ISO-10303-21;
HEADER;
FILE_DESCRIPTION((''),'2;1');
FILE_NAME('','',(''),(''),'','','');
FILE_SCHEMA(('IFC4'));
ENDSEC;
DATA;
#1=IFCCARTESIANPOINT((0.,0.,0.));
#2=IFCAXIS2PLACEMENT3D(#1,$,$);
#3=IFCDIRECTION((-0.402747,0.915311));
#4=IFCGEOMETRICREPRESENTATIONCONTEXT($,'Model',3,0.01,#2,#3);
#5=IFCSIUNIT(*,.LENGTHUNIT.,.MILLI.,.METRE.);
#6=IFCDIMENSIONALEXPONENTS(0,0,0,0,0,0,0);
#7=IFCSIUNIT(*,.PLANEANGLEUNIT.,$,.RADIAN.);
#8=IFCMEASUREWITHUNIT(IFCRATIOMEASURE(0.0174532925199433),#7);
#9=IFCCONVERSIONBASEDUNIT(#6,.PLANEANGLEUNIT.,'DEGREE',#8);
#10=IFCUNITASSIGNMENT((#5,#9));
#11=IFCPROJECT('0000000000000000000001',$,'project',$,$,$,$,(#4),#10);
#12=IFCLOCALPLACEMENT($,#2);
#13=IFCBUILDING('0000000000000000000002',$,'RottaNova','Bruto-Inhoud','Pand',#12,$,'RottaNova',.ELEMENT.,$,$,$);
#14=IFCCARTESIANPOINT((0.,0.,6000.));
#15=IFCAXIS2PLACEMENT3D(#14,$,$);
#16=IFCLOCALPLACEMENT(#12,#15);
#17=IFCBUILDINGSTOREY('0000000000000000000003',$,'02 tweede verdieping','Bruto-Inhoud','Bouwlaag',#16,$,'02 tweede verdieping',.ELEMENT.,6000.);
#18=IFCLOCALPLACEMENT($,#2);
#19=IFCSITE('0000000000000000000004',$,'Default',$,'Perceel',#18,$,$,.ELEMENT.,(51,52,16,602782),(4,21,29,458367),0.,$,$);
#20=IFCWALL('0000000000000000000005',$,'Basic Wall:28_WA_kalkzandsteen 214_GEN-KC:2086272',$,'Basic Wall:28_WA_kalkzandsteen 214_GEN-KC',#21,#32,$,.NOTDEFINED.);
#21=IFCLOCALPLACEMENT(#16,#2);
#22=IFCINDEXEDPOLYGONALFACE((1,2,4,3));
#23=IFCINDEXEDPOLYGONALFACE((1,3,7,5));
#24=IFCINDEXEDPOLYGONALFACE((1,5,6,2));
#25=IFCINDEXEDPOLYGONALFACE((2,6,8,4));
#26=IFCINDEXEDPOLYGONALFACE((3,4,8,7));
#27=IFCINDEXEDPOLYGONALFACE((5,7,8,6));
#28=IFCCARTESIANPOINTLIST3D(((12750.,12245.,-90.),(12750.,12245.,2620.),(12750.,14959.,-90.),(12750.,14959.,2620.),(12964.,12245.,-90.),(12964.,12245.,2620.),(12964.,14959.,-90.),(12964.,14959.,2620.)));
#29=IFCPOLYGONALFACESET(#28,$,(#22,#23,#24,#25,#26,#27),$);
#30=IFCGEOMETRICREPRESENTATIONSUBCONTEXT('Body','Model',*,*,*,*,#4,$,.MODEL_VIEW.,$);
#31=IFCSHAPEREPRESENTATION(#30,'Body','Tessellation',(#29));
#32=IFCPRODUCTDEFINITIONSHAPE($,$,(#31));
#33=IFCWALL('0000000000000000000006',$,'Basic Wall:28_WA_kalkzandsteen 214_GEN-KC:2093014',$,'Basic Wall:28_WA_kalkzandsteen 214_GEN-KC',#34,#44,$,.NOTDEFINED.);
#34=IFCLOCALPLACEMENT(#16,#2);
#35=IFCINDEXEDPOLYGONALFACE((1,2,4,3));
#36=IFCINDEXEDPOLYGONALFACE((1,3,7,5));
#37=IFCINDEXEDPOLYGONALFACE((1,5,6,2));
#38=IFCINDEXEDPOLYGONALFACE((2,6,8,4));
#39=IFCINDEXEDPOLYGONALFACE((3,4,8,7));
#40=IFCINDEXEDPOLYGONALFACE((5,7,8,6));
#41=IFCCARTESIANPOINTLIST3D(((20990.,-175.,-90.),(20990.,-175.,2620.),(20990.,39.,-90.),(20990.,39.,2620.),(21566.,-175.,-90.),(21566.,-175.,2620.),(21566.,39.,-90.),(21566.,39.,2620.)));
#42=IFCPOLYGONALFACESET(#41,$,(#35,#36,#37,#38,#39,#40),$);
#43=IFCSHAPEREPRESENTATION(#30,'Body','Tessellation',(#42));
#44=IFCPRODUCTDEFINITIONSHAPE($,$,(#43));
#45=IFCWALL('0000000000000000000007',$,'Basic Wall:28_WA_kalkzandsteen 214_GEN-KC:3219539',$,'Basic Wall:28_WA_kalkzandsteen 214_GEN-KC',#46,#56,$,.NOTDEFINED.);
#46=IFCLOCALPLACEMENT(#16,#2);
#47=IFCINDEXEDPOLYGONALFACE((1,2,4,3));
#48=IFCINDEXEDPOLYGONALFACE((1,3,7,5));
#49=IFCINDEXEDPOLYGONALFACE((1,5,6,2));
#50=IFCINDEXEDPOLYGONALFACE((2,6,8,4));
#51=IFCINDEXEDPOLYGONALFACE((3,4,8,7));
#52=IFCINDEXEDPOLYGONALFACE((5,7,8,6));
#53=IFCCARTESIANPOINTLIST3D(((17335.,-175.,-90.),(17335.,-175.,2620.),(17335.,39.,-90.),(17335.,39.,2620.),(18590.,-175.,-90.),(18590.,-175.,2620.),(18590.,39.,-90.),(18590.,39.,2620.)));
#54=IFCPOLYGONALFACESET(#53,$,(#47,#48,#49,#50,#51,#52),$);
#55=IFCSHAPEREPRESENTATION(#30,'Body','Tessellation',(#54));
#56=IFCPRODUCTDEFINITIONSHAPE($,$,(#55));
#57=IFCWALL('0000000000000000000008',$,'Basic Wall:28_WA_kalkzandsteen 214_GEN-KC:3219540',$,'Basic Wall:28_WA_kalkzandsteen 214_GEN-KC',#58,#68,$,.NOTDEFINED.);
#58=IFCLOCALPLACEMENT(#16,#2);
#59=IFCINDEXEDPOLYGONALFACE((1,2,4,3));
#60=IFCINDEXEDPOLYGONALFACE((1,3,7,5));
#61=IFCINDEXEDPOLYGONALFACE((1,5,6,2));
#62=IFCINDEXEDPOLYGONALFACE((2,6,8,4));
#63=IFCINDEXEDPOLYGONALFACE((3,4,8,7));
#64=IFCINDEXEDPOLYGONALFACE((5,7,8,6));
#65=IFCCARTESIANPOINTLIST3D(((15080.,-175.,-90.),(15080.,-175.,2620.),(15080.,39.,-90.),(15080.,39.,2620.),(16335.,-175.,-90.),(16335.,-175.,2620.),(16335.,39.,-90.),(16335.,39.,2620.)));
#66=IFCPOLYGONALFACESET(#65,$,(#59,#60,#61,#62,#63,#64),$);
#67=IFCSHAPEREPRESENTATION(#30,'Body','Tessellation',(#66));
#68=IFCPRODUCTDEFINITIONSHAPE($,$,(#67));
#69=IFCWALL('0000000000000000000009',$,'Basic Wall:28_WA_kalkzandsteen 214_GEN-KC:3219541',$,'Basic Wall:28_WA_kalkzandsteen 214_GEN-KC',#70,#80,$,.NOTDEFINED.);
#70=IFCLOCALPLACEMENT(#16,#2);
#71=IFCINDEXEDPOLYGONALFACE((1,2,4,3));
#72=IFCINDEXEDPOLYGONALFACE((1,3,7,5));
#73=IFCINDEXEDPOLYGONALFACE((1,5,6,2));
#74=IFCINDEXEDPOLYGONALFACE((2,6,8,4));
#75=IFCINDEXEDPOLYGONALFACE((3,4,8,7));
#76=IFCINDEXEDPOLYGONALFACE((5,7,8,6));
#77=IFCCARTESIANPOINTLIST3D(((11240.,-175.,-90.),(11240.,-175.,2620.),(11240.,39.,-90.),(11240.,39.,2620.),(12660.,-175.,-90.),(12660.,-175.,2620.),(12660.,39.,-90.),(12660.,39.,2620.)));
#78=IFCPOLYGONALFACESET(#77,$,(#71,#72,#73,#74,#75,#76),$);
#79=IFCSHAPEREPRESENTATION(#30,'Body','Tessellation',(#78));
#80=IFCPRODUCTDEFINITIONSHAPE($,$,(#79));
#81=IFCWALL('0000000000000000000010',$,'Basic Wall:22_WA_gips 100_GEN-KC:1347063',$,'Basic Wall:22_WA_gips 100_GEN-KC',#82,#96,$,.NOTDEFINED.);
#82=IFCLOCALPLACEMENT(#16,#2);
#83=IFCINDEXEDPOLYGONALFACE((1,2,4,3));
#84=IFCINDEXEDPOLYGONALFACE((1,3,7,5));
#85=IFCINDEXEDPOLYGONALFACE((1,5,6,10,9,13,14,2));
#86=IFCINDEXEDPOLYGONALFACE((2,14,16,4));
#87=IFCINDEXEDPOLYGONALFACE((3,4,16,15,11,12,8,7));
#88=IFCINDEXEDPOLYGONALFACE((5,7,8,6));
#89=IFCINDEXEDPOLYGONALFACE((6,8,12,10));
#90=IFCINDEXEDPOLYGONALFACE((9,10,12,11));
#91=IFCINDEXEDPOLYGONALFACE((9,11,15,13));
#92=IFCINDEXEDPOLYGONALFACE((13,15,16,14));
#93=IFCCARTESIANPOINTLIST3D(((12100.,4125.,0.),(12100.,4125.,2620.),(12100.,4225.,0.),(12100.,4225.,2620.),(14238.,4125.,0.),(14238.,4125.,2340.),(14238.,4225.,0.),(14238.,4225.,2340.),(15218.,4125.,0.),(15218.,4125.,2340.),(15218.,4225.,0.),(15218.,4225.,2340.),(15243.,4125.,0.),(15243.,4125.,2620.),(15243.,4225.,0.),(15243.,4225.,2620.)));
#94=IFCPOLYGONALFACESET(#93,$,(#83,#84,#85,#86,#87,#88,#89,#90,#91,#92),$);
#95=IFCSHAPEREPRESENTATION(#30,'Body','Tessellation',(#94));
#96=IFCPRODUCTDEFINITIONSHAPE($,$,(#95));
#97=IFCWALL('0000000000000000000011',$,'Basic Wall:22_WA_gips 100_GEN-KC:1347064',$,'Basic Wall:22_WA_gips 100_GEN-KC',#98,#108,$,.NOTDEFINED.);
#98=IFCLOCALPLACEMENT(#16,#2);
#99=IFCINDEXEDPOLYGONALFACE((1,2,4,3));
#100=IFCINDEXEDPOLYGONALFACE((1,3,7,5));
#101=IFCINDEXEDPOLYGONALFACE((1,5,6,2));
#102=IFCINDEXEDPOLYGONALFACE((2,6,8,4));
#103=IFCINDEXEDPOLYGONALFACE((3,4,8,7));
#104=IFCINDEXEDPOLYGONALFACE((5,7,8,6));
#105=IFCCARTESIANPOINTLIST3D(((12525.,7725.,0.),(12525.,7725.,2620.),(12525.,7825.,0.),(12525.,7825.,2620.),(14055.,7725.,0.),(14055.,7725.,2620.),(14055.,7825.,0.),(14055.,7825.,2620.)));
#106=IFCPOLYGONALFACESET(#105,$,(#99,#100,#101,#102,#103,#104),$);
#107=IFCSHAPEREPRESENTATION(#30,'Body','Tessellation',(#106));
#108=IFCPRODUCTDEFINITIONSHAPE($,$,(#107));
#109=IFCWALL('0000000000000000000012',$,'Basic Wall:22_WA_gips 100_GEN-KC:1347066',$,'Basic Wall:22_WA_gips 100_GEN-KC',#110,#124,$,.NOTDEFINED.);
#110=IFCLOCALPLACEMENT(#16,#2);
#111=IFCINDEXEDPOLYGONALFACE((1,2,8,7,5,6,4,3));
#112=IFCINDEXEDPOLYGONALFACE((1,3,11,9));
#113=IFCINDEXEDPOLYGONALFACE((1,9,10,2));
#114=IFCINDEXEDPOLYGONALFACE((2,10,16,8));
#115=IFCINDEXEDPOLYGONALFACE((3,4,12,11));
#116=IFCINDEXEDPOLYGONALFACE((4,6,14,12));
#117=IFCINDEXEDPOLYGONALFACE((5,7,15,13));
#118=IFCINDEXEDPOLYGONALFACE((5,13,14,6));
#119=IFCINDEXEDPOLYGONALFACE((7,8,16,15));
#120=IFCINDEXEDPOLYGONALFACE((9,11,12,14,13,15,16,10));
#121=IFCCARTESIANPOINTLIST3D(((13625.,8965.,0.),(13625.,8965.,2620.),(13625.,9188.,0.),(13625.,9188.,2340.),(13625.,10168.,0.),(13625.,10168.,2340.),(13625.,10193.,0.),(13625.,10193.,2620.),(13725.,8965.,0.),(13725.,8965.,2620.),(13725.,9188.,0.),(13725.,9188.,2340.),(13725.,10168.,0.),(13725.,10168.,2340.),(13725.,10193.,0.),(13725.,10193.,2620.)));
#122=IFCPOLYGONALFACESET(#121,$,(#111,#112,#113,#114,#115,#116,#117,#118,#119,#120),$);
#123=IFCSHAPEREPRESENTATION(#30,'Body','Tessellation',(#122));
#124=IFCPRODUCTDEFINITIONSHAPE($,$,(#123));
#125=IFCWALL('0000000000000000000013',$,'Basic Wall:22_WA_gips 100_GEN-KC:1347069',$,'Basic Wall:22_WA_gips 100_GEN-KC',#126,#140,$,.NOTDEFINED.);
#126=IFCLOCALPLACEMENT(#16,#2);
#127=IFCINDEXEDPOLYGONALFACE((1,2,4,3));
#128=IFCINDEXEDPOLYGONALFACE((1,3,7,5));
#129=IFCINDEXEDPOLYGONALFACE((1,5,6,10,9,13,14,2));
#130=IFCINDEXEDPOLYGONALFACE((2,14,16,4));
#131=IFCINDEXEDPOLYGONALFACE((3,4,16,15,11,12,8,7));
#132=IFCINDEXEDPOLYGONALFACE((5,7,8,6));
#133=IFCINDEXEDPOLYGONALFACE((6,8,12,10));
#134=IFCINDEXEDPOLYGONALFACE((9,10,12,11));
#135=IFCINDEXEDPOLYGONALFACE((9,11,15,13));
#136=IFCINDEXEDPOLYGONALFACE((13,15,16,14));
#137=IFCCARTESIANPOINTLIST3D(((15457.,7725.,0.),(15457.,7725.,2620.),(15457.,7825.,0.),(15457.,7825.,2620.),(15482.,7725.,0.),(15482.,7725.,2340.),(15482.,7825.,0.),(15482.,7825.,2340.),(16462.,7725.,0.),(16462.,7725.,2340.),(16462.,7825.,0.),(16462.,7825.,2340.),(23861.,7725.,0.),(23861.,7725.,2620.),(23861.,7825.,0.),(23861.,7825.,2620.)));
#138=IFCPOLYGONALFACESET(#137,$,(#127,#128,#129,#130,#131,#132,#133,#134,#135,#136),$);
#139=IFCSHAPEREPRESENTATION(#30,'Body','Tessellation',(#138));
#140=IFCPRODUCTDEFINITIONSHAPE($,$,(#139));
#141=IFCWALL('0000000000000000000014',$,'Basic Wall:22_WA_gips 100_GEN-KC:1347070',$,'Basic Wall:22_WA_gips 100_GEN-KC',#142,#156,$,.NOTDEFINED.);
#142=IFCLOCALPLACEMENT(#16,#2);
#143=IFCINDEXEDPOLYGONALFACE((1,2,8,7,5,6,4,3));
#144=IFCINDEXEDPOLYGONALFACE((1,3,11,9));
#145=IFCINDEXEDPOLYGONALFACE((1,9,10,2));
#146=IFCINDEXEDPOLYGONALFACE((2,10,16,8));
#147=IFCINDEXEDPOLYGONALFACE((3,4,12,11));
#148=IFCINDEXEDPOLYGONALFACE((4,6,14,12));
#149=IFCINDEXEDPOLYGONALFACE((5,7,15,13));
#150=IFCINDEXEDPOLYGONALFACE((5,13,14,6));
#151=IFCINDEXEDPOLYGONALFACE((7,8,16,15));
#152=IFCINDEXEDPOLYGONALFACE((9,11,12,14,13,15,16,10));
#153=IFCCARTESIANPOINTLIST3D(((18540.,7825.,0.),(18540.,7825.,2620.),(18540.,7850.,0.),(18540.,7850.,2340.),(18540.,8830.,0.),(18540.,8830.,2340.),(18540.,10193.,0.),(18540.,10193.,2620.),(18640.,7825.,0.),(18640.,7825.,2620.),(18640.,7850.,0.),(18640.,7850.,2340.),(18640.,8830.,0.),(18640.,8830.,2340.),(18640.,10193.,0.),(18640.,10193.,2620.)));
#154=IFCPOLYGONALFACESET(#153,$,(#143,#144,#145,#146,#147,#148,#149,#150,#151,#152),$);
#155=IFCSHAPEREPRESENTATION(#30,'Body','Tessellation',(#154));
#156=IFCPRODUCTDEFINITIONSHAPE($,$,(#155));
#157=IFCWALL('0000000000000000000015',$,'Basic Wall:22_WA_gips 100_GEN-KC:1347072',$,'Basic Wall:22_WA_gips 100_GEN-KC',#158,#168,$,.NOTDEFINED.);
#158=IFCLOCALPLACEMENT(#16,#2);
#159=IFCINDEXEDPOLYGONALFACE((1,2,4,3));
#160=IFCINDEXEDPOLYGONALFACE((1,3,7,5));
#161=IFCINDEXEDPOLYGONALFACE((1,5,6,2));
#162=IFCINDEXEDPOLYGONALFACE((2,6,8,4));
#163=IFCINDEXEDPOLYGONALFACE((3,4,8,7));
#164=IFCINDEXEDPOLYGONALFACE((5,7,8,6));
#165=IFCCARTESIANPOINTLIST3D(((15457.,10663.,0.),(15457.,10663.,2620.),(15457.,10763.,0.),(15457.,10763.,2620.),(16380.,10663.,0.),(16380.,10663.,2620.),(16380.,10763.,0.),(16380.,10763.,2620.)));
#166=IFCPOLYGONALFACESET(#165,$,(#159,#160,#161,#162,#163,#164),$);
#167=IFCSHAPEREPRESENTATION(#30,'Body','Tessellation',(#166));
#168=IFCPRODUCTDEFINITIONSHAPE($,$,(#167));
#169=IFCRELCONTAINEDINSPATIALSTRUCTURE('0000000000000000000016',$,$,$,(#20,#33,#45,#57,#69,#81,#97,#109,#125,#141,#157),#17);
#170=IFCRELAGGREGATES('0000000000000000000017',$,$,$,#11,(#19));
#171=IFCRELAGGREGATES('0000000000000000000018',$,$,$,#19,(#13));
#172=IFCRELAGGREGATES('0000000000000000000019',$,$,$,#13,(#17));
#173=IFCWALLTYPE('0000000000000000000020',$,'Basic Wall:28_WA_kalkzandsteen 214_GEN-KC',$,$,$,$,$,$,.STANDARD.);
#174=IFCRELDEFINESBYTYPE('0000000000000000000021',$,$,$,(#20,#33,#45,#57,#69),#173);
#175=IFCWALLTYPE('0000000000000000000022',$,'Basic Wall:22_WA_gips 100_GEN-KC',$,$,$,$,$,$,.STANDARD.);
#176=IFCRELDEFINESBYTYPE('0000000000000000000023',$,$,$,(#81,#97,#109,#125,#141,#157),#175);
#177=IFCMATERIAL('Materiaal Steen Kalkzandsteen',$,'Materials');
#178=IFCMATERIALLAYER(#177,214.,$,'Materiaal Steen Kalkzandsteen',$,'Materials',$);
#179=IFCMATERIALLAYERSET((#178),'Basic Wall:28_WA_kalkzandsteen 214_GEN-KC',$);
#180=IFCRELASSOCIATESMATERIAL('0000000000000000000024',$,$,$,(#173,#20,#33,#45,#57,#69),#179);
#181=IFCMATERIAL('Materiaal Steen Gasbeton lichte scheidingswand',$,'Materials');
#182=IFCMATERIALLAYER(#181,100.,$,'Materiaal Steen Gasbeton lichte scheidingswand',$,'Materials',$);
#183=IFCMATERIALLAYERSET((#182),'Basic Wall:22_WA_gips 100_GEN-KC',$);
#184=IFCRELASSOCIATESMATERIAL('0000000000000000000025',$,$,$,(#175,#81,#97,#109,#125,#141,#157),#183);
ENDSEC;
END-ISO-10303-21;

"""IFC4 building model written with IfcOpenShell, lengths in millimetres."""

from ifc_helpers import new_model, entity, si_unit, converted_unit, direction, frame, frame_2d, origin, place, context, subcontext, project, spatial, rectangle, extrude, material, layer, layer_set, type_object, element, save


model = new_model("IFC4")

# Units and contexts
model_context = context("Model", 3, precision=0.01, world=origin(), true_north=direction((-0.402747, 0.915311)))
body_context = subcontext(model_context, "Body", "Model", "MODEL_VIEW")
ifc_project = project(units=[si_unit("LENGTHUNIT", "METRE", prefix="MILLI"), converted_unit("PLANEANGLEUNIT", "DEGREE", entity("IfcRatioMeasure", 0.0174532925199433), si_unit("PLANEANGLEUNIT", "RADIAN"), dimensions=[0, 0, 0, 0, 0, 0, 0])], contexts=[model_context])

# Site, building, storey
site_placement = place(None, origin())
site = spatial("IfcSite", under=ifc_project, at=site_placement, Name="Default", ObjectType="Perceel", CompositionType="ELEMENT", RefLatitude=(51, 52, 16, 602782), RefLongitude=(4, 21, 29, 458367), RefElevation=0.0)
building_placement = place(None, origin())
building = spatial("IfcBuilding", under=site, at=building_placement, Name="RottaNova", Description="Bruto-Inhoud", ObjectType="Pand", LongName="RottaNova", CompositionType="ELEMENT")
storey_placement = place(building_placement, frame((0.0, 0.0, 6000.0)))
storey = spatial("IfcBuildingStorey", under=building, at=storey_placement, Name="02 tweede verdieping", Description="Bruto-Inhoud", ObjectType="Bouwlaag", LongName="02 tweede verdieping", CompositionType="ELEMENT", Elevation=6000.0)

# Walls
ifc_material_1 = material(Name="Materiaal Steen Kalkzandsteen", Category="Materials")
ifc_layer_1 = layer(ifc_material_1, 214.0, Name="Materiaal Steen Kalkzandsteen", Category="Materials")
ifc_layer_set_1 = layer_set([ifc_layer_1], Name="Basic Wall:28_WA_kalkzandsteen 214_GEN-KC")
wall_type_1 = type_object("IfcWallType", Name="Basic Wall:28_WA_kalkzandsteen 214_GEN-KC", PredefinedType="STANDARD", material=ifc_layer_set_1)
wall_1_placement = place(storey_placement, frame((12857.0, 12245.0, -90.0), z_axis=(0.0, 0.0, 1.0), x_axis=(0.0, 1.0, 0.0)))
element("IfcWall", 1, at=wall_1_placement, inside=storey, type_object=wall_type_1, material=ifc_layer_set_1, Name="Basic Wall:28_WA_kalkzandsteen 214_GEN-KC:2086272", ObjectType="Basic Wall:28_WA_kalkzandsteen 214_GEN-KC", PredefinedType="NOTDEFINED", context=body_context, shape_type="SweptSolid", body=[
    extrude(rectangle(XDim=2714.0, YDim=214.0, at=frame_2d((1357.0, 0.0), x_axis=(-1.0, 0.0))), origin(), (0.0, 0.0, 1.0), 2710.0),
])
wall_2_placement = place(storey_placement, frame((21566.0, -68.0, -90.0), z_axis=(0.0, 0.0, 1.0), x_axis=(-1.0, 0.0, 0.0)))
element("IfcWall", 2, at=wall_2_placement, inside=storey, type_object=wall_type_1, material=ifc_layer_set_1, Name="Basic Wall:28_WA_kalkzandsteen 214_GEN-KC:2093014", ObjectType="Basic Wall:28_WA_kalkzandsteen 214_GEN-KC", PredefinedType="NOTDEFINED", context=body_context, shape_type="SweptSolid", body=[
    extrude(rectangle(XDim=576.0, YDim=214.0, at=frame_2d((288.0, 0.0), x_axis=(-1.0, 0.0))), origin(), (0.0, 0.0, 1.0), 2710.0),
])
wall_3_placement = place(storey_placement, frame((18590.0, -68.0, -90.0), z_axis=(0.0, 0.0, 1.0), x_axis=(-1.0, 0.0, 0.0)))
element("IfcWall", 3, at=wall_3_placement, inside=storey, type_object=wall_type_1, material=ifc_layer_set_1, Name="Basic Wall:28_WA_kalkzandsteen 214_GEN-KC:3219539", ObjectType="Basic Wall:28_WA_kalkzandsteen 214_GEN-KC", PredefinedType="NOTDEFINED", context=body_context, shape_type="SweptSolid", body=[
    extrude(rectangle(XDim=1255.0, YDim=214.0, at=frame_2d((627.5, 0.0), x_axis=(-1.0, 0.0))), origin(), (0.0, 0.0, 1.0), 2710.0),
])
wall_4_placement = place(storey_placement, frame((16335.0, -68.0, -90.0), z_axis=(0.0, 0.0, 1.0), x_axis=(-1.0, 0.0, 0.0)))
element("IfcWall", 4, at=wall_4_placement, inside=storey, type_object=wall_type_1, material=ifc_layer_set_1, Name="Basic Wall:28_WA_kalkzandsteen 214_GEN-KC:3219540", ObjectType="Basic Wall:28_WA_kalkzandsteen 214_GEN-KC", PredefinedType="NOTDEFINED", context=body_context, shape_type="SweptSolid", body=[
    extrude(rectangle(XDim=1255.0, YDim=214.0, at=frame_2d((627.5, 0.0), x_axis=(-1.0, 0.0))), origin(), (0.0, 0.0, 1.0), 2710.0),
])
wall_5_placement = place(storey_placement, frame((12660.0, -68.0, -90.0), z_axis=(0.0, 0.0, 1.0), x_axis=(-1.0, 0.0, 0.0)))
element("IfcWall", 5, at=wall_5_placement, inside=storey, type_object=wall_type_1, material=ifc_layer_set_1, Name="Basic Wall:28_WA_kalkzandsteen 214_GEN-KC:3219541", ObjectType="Basic Wall:28_WA_kalkzandsteen 214_GEN-KC", PredefinedType="NOTDEFINED", context=body_context, shape_type="SweptSolid", body=[
    extrude(rectangle(XDim=1420.0, YDim=214.0, at=frame_2d((710.0, 0.0), x_axis=(-1.0, 0.0))), origin(), (0.0, 0.0, 1.0), 2710.0),
])

# Wall, opening
ifc_material_2 = material(Name="Materiaal Steen Gasbeton lichte scheidingswand", Category="Materials")
ifc_layer_2 = layer(ifc_material_2, 100.0, Name="Materiaal Steen Gasbeton lichte scheidingswand", Category="Materials")
ifc_layer_set_2 = layer_set([ifc_layer_2], Name="Basic Wall:22_WA_gips 100_GEN-KC")
wall_type_2 = type_object("IfcWallType", Name="Basic Wall:22_WA_gips 100_GEN-KC", PredefinedType="STANDARD", material=ifc_layer_set_2)
wall_6_placement = place(storey_placement, frame((15243.0, 4175.0, 0.0), z_axis=(0.0, 0.0, 1.0), x_axis=(-1.0, 0.0, 0.0)))
wall_6 = element("IfcWall", 6, at=wall_6_placement, inside=storey, type_object=wall_type_2, material=ifc_layer_set_2, Name="Basic Wall:22_WA_gips 100_GEN-KC:1347063", ObjectType="Basic Wall:22_WA_gips 100_GEN-KC", PredefinedType="NOTDEFINED", context=body_context, shape_type="SweptSolid", body=[
    extrude(rectangle(XDim=3143.0, YDim=100.0, at=frame_2d((1571.5, 0.0), x_axis=(-1.0, 0.0))), origin(), (0.0, 0.0, 1.0), 2620.0),
])
opening_1_placement = place(wall_6_placement, frame((25.0, -50.0, -90.0)))
element("IfcOpeningElement", 7, at=opening_1_placement, cuts=wall_6, PredefinedType="OPENING", context=body_context, shape_type="SweptSolid", body=[
    extrude(rectangle(XDim=2430.0, YDim=980.0, at=frame_2d((1215.0, 490.0), x_axis=(1.0, 0.0))), frame((0.0, 0.0, 0.0), z_axis=(0.0, 1.0, 0.0), x_axis=(0.0, 0.0, 1.0)), (0.0, 0.0, 1.0), 100.0),
])

# Wall
wall_7_placement = place(storey_placement, frame((14055.0, 7775.0, 0.0), z_axis=(0.0, 0.0, 1.0), x_axis=(-1.0, 0.0, 0.0)))
element("IfcWall", 8, at=wall_7_placement, inside=storey, type_object=wall_type_2, material=ifc_layer_set_2, Name="Basic Wall:22_WA_gips 100_GEN-KC:1347064", ObjectType="Basic Wall:22_WA_gips 100_GEN-KC", PredefinedType="NOTDEFINED", context=body_context, shape_type="SweptSolid", body=[
    extrude(rectangle(XDim=1530.0, YDim=100.0, at=frame_2d((765.0, 0.0), x_axis=(-1.0, 0.0))), origin(), (0.0, 0.0, 1.0), 2620.0),
])

# Walls, openings
wall_8_placement = place(storey_placement, frame((13675.0, 8965.0, 0.0), z_axis=(0.0, 0.0, 1.0), x_axis=(0.0, 1.0, 0.0)))
wall_8 = element("IfcWall", 9, at=wall_8_placement, inside=storey, type_object=wall_type_2, material=ifc_layer_set_2, Name="Basic Wall:22_WA_gips 100_GEN-KC:1347066", ObjectType="Basic Wall:22_WA_gips 100_GEN-KC", PredefinedType="NOTDEFINED", context=body_context, shape_type="SweptSolid", body=[
    extrude(rectangle(XDim=1228.0, YDim=100.0, at=frame_2d((614.0, 0.0), x_axis=(1.0, 0.0))), origin(), (0.0, 0.0, 1.0), 2620.0),
])
opening_2_placement = place(wall_8_placement, frame((1203.0, 50.0, -90.0)))
element("IfcOpeningElement", 10, at=opening_2_placement, cuts=wall_8, PredefinedType="OPENING", context=body_context, shape_type="SweptSolid", body=[
    extrude(rectangle(XDim=2430.0, YDim=980.0, at=frame_2d((1215.0, 490.0), x_axis=(1.0, 0.0))), frame((0.0, 0.0, 0.0), z_axis=(0.0, -1.0, 0.0), x_axis=(0.0, 0.0, 1.0)), (0.0, 0.0, 1.0), 100.0),
])
wall_9_placement = place(storey_placement, frame((23861.0, 7775.0, 0.0), z_axis=(0.0, 0.0, 1.0), x_axis=(-1.0, 0.0, 0.0)))
wall_9 = element("IfcWall", 11, at=wall_9_placement, inside=storey, type_object=wall_type_2, material=ifc_layer_set_2, Name="Basic Wall:22_WA_gips 100_GEN-KC:1347069", ObjectType="Basic Wall:22_WA_gips 100_GEN-KC", PredefinedType="NOTDEFINED", context=body_context, shape_type="SweptSolid", body=[
    extrude(rectangle(XDim=8404.0, YDim=100.0, at=frame_2d((4202.0, 0.0), x_axis=(1.0, 0.0))), origin(), (0.0, 0.0, 1.0), 2620.0),
])
opening_3_placement = place(wall_9_placement, frame((7399.0, -50.0, -90.0)))
element("IfcOpeningElement", 12, at=opening_3_placement, cuts=wall_9, PredefinedType="OPENING", context=body_context, shape_type="SweptSolid", body=[
    extrude(rectangle(XDim=2430.0, YDim=980.0, at=frame_2d((1215.0, 490.0), x_axis=(1.0, 0.0))), frame((0.0, 0.0, 0.0), z_axis=(0.0, 1.0, 0.0), x_axis=(0.0, 0.0, 1.0)), (0.0, 0.0, 1.0), 100.0),
])
wall_10_placement = place(storey_placement, frame((18590.0, 10193.0, 0.0), z_axis=(0.0, 0.0, 1.0), x_axis=(0.0, -1.0, 0.0)))
wall_10 = element("IfcWall", 13, at=wall_10_placement, inside=storey, type_object=wall_type_2, material=ifc_layer_set_2, Name="Basic Wall:22_WA_gips 100_GEN-KC:1347070", ObjectType="Basic Wall:22_WA_gips 100_GEN-KC", PredefinedType="NOTDEFINED", context=body_context, shape_type="SweptSolid", body=[
    extrude(rectangle(XDim=2368.0, YDim=100.0, at=frame_2d((1184.0, 0.0), x_axis=(1.0, 0.0))), origin(), (0.0, 0.0, 1.0), 2620.0),
])
opening_4_placement = place(wall_10_placement, frame((1363.0, -50.0, -90.0)))
element("IfcOpeningElement", 14, at=opening_4_placement, cuts=wall_10, PredefinedType="OPENING", context=body_context, shape_type="SweptSolid", body=[
    extrude(rectangle(XDim=2430.0, YDim=980.0, at=frame_2d((1215.0, 490.0), x_axis=(1.0, 0.0))), frame((0.0, 0.0, 0.0), z_axis=(0.0, 1.0, 0.0), x_axis=(0.0, 0.0, 1.0)), (0.0, 0.0, 1.0), 100.0),
])

# Wall
wall_11_placement = place(storey_placement, frame((16380.0, 10713.0, 0.0), z_axis=(0.0, 0.0, 1.0), x_axis=(-1.0, 0.0, 0.0)))
element("IfcWall", 15, at=wall_11_placement, inside=storey, type_object=wall_type_2, material=ifc_layer_set_2, Name="Basic Wall:22_WA_gips 100_GEN-KC:1347072", ObjectType="Basic Wall:22_WA_gips 100_GEN-KC", PredefinedType="NOTDEFINED", context=body_context, shape_type="SweptSolid", body=[
    extrude(rectangle(XDim=923.0, YDim=100.0, at=frame_2d((461.5, 0.0), x_axis=(-1.0, 0.0))), origin(), (0.0, 0.0, 1.0), 2620.0),
])

save(model, "model.ifc")
